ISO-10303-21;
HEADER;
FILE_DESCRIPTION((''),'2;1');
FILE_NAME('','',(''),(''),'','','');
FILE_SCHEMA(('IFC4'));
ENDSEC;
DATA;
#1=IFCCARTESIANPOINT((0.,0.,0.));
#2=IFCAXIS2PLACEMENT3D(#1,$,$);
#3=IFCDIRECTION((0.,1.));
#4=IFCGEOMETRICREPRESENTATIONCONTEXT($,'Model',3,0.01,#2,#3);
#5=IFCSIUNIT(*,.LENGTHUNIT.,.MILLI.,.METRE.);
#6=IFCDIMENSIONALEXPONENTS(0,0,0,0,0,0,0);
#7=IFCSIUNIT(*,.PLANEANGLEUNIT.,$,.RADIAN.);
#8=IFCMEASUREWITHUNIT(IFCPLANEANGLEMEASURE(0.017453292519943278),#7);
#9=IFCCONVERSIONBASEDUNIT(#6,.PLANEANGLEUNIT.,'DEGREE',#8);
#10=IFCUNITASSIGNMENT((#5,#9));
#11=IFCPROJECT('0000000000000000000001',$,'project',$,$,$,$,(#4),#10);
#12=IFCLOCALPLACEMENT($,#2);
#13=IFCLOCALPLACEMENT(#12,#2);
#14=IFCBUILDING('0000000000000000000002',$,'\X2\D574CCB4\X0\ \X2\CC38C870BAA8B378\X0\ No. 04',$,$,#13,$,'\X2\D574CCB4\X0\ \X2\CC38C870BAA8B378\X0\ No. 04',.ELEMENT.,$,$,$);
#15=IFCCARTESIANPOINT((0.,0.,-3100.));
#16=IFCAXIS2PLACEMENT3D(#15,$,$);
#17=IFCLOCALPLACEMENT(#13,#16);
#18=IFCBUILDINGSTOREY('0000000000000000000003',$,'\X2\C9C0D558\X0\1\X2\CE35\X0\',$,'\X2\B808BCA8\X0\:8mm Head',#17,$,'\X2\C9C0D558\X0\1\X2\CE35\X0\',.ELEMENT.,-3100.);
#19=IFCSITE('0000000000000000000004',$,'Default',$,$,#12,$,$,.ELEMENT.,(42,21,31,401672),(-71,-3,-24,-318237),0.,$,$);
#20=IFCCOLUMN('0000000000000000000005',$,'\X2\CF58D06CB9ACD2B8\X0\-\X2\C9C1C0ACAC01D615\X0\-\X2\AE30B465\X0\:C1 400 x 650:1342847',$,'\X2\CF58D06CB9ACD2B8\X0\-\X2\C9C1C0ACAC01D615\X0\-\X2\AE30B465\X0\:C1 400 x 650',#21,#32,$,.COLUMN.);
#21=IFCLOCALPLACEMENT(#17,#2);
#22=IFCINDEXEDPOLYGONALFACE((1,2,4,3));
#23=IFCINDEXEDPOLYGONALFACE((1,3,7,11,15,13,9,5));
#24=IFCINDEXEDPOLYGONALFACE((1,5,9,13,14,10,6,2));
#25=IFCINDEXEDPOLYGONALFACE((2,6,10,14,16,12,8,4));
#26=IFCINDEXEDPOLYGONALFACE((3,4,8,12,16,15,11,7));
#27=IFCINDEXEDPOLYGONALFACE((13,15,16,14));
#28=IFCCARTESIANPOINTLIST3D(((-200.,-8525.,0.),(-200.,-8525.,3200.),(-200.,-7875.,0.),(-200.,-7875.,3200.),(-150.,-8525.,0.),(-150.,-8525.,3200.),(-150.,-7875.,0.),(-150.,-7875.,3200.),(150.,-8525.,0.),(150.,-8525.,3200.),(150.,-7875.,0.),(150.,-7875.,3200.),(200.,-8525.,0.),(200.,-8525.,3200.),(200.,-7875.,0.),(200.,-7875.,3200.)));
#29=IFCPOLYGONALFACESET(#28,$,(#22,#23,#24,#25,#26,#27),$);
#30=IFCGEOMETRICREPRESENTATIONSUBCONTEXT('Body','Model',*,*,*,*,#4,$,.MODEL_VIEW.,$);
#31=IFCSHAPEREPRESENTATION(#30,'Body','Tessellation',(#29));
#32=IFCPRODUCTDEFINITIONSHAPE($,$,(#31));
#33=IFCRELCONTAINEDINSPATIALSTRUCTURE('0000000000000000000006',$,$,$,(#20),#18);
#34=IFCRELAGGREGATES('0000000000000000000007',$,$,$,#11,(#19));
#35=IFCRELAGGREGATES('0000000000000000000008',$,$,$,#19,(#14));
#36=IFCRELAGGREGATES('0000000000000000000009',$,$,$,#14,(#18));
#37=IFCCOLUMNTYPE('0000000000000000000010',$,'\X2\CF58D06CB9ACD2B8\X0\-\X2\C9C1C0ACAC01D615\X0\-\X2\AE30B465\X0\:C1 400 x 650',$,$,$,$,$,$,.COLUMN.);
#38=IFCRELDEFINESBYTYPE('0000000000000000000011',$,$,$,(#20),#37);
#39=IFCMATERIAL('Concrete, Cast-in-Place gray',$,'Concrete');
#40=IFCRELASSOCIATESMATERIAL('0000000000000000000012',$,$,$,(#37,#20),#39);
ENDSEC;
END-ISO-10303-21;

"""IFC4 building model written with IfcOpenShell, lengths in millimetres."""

from ifc_helpers import new_model, entity, si_unit, converted_unit, direction, frame, origin, place, context, subcontext, project, spatial, indexed_curve, outline, extrude, source, transform, mapped, material, type_object, type_shapes, element, save


model = new_model("IFC4")

# Units and contexts
model_context = context("Model", 3, precision=0.01, world=origin(), true_north=direction((0.0, 1.0)))
body_context = subcontext(model_context, "Body", "Model", "MODEL_VIEW")
ifc_project = project(units=[si_unit("LENGTHUNIT", "METRE", prefix="MILLI"), converted_unit("PLANEANGLEUNIT", "DEGREE", entity("IfcPlaneAngleMeasure", 0.017453292519943278), si_unit("PLANEANGLEUNIT", "RADIAN"), dimensions=[0, 0, 0, 0, 0, 0, 0])], contexts=[model_context])

# Site, building, storey
site_placement = place(None, origin())
site = spatial("IfcSite", under=ifc_project, at=site_placement, Name="Default", CompositionType="ELEMENT", RefLatitude=(42, 21, 31, 401672), RefLongitude=(-71, -3, -24, -318237), RefElevation=0.0)
building_placement = place(site_placement, origin())
building = spatial("IfcBuilding", under=site, at=building_placement, Name="해체 참조모델 No. 04", LongName="해체 참조모델 No. 04", CompositionType="ELEMENT")
storey_placement = place(building_placement, frame((0.0, 0.0, -3100.0)))
storey = spatial("IfcBuildingStorey", under=building, at=storey_placement, Name="지하1층", ObjectType="레벨:8mm Head", LongName="지하1층", CompositionType="ELEMENT", Elevation=-3100.0)

# Column
ifc_material = material(Name="Concrete, Cast-in-Place gray", Category="Concrete")
column_type_1 = type_object("IfcColumnType", Name="콘크리트-직사각형-기둥:C1 400 x 650", PredefinedType="COLUMN", material=ifc_material)
shared_shape_1 = source(origin(), body_context, "Body", "SweptSolid", [
    extrude(outline(indexed_curve([(-200.0, -325.0), (-150.0, -325.0), (150.0, -325.0), (200.0, -325.0), (200.0, 325.0), (150.0, 325.0), (-150.0, 325.0), (-200.0, 325.0), (-200.0, -325.0)], self_intersect=False)), frame((0.0, -8200.0, -3100.0), z_axis=(0.0, 0.0, 1.0), x_axis=(-1.0, 0.0, 0.0)), (0.0, 0.0, 1.0), 3200.0),
])
type_shapes(column_type_1, [shared_shape_1])
column_1_placement = place(storey_placement, frame((0.0, 0.0, 3100.0)))
element("IfcColumn", 1, at=column_1_placement, inside=storey, type_object=column_type_1, material=ifc_material, Name="콘크리트-직사각형-기둥:C1 400 x 650:1342847", ObjectType="콘크리트-직사각형-기둥:C1 400 x 650", PredefinedType="COLUMN", context=body_context, shape_type="MappedRepresentation", body=[
    mapped(shared_shape_1, transform((0.0, 0.0, 0.0), scale=1.0)),
])

save(model, "model.ifc")
